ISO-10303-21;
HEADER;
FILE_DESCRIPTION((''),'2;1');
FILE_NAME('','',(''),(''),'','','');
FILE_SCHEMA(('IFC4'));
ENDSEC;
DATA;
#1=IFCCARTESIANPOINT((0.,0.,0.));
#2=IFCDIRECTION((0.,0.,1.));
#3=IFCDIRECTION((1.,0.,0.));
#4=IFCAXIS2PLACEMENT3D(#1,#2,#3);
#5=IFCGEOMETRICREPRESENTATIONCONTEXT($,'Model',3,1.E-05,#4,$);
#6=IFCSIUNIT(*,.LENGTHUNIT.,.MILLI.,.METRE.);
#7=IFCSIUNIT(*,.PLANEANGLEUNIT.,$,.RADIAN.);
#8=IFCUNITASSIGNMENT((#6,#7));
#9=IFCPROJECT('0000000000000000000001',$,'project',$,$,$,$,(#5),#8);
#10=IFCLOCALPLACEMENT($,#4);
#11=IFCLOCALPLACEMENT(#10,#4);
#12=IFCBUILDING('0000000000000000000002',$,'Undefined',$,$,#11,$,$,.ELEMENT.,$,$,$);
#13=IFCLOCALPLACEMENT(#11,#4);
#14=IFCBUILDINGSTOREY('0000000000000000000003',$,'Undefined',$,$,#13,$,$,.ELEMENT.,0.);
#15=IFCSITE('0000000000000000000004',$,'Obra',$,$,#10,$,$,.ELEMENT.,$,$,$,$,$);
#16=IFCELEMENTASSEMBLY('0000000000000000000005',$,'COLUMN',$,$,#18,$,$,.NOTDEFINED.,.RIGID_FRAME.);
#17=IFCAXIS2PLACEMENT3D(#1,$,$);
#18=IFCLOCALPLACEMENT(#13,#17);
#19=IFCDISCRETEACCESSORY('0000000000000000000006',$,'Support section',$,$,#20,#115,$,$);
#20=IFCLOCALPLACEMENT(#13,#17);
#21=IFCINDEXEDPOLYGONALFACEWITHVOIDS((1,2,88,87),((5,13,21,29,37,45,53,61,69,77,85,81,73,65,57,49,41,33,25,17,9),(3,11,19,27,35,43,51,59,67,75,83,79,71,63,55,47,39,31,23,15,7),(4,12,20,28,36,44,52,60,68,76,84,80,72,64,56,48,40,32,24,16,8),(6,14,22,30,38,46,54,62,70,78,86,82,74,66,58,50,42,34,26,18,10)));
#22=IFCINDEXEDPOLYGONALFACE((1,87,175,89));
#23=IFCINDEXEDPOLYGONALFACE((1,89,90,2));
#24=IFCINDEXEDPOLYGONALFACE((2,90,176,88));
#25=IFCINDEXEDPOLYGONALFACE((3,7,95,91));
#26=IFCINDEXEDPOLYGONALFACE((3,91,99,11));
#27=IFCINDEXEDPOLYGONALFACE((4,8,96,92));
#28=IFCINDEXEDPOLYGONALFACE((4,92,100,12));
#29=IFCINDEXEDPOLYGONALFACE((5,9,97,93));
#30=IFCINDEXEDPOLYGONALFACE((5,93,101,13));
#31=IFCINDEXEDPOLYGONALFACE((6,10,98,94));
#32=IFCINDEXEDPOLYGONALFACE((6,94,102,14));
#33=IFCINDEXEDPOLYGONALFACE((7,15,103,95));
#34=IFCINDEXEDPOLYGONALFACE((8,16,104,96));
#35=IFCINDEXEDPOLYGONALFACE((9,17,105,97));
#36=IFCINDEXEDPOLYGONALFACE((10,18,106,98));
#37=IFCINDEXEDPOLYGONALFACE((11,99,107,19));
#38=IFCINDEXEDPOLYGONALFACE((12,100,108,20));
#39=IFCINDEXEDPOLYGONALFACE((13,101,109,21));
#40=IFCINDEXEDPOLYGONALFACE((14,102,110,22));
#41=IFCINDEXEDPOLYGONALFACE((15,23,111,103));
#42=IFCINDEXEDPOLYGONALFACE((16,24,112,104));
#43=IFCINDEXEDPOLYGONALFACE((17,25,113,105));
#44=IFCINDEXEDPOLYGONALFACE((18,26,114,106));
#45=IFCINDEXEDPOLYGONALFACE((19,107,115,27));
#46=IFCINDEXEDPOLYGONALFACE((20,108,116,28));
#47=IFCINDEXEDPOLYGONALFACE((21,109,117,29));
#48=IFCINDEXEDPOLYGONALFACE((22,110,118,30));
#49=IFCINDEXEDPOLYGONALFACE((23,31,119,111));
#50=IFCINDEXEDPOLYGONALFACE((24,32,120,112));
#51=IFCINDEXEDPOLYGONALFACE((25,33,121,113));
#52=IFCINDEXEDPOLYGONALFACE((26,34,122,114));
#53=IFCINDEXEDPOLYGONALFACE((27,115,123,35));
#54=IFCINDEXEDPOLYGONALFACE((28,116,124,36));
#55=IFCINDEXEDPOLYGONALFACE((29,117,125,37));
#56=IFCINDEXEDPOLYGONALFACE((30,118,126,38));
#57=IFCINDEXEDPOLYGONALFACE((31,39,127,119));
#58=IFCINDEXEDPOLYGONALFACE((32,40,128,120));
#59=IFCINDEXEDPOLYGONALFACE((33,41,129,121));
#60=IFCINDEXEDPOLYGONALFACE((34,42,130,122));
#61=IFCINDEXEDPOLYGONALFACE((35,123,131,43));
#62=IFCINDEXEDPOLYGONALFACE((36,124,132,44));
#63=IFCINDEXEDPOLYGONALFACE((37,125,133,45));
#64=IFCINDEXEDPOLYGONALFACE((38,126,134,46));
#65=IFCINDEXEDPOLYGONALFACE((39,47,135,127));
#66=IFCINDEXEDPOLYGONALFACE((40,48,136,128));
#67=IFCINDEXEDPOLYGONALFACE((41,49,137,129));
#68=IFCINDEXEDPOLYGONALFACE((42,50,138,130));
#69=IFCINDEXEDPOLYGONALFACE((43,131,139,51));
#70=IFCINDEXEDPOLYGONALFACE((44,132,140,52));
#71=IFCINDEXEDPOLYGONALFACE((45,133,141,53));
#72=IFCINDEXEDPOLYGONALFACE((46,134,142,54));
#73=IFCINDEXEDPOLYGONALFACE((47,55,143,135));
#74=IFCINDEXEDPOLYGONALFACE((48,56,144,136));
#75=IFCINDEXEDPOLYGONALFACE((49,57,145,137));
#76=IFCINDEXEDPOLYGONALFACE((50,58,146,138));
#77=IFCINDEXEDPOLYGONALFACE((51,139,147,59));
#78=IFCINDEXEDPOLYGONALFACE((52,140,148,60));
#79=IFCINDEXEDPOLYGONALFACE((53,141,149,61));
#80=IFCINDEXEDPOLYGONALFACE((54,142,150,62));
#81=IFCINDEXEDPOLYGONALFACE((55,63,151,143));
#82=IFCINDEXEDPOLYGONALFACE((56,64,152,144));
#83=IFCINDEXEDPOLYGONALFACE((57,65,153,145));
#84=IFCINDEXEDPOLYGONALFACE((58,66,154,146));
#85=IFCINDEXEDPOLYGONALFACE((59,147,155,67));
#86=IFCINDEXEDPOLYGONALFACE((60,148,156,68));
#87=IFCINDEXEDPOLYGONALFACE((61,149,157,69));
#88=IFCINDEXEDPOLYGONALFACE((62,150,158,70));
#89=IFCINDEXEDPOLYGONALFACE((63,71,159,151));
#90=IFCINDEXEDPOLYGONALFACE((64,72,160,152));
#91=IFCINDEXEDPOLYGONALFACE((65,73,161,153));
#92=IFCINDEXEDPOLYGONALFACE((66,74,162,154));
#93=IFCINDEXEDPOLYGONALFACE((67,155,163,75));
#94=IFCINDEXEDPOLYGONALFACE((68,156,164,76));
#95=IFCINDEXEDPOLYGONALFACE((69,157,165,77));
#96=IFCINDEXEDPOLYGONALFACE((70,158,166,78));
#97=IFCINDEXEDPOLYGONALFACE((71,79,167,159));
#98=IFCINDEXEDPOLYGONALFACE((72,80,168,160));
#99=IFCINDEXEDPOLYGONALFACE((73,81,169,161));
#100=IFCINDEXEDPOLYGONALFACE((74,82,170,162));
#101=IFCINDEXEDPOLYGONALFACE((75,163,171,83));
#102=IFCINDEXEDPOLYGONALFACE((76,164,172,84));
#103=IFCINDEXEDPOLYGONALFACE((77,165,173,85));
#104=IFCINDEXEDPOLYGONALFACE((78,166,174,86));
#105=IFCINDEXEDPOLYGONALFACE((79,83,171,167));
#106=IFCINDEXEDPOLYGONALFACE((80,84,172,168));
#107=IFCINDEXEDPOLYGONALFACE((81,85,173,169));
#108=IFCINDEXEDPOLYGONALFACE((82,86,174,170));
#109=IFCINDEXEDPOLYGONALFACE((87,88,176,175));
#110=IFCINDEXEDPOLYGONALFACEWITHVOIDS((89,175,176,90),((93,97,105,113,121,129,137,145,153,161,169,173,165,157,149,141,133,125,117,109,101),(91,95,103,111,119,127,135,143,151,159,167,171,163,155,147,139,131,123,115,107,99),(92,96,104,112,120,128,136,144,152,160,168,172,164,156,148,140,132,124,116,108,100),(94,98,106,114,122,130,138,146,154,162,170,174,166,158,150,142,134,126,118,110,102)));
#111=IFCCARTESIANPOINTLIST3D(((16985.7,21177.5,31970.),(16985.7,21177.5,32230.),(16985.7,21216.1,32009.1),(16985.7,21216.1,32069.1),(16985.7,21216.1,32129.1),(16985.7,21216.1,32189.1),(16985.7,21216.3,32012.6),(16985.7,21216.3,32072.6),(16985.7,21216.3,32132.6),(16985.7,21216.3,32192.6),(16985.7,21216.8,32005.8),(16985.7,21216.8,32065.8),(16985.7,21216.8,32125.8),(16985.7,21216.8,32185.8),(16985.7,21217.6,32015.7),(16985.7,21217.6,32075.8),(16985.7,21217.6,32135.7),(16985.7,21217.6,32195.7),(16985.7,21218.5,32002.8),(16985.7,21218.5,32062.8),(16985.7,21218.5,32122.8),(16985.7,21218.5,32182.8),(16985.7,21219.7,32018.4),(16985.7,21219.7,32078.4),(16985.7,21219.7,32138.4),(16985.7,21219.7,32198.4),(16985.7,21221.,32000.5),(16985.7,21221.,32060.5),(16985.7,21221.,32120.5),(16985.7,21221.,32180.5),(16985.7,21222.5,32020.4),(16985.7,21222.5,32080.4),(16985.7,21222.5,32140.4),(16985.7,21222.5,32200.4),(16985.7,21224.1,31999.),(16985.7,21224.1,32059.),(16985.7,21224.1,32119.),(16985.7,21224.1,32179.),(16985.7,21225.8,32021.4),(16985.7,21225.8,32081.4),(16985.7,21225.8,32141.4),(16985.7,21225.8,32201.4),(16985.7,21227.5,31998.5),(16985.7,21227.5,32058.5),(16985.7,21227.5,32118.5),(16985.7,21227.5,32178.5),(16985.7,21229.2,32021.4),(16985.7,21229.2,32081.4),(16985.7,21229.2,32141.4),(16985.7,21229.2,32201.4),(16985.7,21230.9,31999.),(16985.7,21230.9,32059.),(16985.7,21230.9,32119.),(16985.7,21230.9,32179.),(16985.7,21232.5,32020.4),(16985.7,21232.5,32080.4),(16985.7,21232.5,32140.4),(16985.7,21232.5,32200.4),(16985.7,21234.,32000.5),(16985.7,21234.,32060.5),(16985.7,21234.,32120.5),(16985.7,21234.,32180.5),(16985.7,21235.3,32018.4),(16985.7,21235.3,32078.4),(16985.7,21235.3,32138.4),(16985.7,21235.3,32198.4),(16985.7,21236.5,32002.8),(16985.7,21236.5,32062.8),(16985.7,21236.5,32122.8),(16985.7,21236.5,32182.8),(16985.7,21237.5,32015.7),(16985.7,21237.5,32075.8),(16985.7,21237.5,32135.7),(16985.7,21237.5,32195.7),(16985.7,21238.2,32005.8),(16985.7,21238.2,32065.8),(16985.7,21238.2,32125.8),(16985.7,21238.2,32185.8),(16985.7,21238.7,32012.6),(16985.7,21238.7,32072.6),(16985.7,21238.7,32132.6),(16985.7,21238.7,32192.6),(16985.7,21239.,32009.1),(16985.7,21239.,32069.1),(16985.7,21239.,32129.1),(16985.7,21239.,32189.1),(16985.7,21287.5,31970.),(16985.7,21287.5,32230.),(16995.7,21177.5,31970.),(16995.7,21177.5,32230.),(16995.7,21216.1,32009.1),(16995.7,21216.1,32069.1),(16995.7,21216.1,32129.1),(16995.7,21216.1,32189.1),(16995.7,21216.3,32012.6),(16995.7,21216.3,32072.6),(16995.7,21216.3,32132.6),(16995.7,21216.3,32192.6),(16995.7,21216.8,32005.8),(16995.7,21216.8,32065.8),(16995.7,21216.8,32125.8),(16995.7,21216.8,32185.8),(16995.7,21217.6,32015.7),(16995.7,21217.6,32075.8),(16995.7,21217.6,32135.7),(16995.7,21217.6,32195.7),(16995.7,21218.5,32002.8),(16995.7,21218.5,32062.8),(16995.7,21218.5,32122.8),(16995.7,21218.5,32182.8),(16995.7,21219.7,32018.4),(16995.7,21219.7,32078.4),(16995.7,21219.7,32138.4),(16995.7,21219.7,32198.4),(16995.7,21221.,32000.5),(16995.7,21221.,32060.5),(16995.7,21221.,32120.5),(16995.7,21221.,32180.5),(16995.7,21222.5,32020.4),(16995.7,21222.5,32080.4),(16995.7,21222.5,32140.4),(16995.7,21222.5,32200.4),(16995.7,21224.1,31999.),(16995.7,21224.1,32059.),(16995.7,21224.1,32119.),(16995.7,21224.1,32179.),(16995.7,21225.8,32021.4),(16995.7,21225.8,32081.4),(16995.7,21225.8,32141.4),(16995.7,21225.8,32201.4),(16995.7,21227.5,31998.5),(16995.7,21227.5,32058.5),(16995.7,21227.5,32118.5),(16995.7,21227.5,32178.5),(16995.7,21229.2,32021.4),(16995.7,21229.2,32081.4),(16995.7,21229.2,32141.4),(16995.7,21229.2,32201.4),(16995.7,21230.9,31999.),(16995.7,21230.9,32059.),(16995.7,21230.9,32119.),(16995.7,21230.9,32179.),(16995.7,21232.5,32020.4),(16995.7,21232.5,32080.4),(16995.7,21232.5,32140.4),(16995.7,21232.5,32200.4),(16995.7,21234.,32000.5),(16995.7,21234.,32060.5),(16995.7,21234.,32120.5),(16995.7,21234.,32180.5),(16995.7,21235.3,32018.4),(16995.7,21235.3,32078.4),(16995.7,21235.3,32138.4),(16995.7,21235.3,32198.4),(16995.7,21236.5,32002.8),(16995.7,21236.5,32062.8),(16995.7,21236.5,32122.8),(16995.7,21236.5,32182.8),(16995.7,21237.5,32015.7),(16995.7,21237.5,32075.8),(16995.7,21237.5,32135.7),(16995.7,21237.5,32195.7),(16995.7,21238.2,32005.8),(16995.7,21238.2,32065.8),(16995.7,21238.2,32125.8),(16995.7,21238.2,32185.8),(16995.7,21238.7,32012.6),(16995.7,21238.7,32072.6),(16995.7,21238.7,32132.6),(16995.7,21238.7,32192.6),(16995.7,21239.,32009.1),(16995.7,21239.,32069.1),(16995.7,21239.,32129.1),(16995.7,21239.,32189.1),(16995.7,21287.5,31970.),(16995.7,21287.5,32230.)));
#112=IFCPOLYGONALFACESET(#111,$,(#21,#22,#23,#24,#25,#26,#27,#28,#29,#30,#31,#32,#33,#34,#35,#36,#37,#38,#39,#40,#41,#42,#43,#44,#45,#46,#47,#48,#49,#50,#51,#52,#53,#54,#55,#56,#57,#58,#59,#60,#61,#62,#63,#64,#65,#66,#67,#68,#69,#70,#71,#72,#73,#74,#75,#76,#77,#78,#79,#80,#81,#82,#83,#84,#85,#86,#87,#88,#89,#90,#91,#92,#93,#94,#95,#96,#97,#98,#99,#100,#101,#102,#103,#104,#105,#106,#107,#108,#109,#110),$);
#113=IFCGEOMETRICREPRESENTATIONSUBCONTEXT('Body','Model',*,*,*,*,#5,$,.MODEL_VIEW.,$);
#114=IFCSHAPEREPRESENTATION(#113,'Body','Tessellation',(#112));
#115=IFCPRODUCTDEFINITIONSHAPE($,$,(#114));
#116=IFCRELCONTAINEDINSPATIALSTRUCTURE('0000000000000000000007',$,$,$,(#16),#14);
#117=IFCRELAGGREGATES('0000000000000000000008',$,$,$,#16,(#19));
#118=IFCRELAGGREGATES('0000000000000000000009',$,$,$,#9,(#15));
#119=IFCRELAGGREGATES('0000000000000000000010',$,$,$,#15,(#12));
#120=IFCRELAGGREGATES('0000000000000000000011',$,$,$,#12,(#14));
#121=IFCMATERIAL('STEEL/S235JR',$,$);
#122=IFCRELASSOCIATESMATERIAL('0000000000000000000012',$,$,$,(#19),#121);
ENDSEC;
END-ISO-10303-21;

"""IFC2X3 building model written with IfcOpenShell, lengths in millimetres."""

from ifc_helpers import new_model, si_unit, frame, origin_with_axes, origin_2d_with_axis, place, context, subcontext, project, spatial, rectangle, circle, extrude, source, transform, mapped, material, element, aggregate, save


model = new_model("IFC2X3")

# Units and contexts
model_context = context("Model", 3, precision=1e-05, world=origin_with_axes())
body_context = subcontext(model_context, "Body", "Model", "MODEL_VIEW")
ifc_project = project(units=[si_unit("LENGTHUNIT", "METRE", prefix="MILLI"), si_unit("PLANEANGLEUNIT", "RADIAN")], contexts=[model_context])

# Site, building, storey
site_placement = place(None, origin_with_axes())
site = spatial("IfcSite", under=ifc_project, at=site_placement, Name="Obra", CompositionType="ELEMENT")
building_placement = place(site_placement, origin_with_axes())
building = spatial("IfcBuilding", under=site, at=building_placement, Name="Undefined", CompositionType="ELEMENT")
storey_placement = place(building_placement, origin_with_axes())
storey = spatial("IfcBuildingStorey", under=building, at=storey_placement, Name="Undefined", CompositionType="ELEMENT", Elevation=0.0)

# Element assembly
assembly_1_placement = place(storey_placement, origin_with_axes())
assembly_1 = element("IfcElementAssembly", 1, at=assembly_1_placement, inside=storey, Name="COLUMN", AssemblyPlace="NOTDEFINED", PredefinedType="RIGID_FRAME")
ifc_material_1 = material(Name="STEEL/S235JR")

# Shared definitions
shared_shape_1 = source(origin_with_axes(), body_context, "Body", "SweptSolid", [
    extrude(circle(Radius=11.5, at=origin_2d_with_axis()), frame((0.0, -14.4, 0.0), z_axis=(0.0, 1.0, 0.0), x_axis=(1.0, 0.0, 0.0)), (0.0, 0.0, 1.0), 10.2),
])

# Discrete accessory, opening
discrete_accessory_1_placement = place(assembly_1_placement, frame((16990.7, 21232.5, 31970.0), z_axis=(0.0, 0.0, 1.0), x_axis=(0.0, 1.0, 0.0)))
discrete_accessory_1 = element("IfcDiscreteAccessory", 2, at=discrete_accessory_1_placement, material=ifc_material_1, Name="Support section", context=body_context, shape_type="SweptSolid", body=[
    extrude(rectangle(XDim=10.0, YDim=110.0, at=origin_2d_with_axis()), frame((0.0, 0.0, 260.0), z_axis=(0.0, 0.0, -1.0), x_axis=(0.0, 1.0, 0.0)), (0.0, 0.0, 1.0), 260.0),
])
opening_1_placement = place(assembly_1_placement, frame((17000.0, 21277.5, 32300.0), z_axis=(0.0, -1.0, 0.0), x_axis=(0.0, 0.0, -1.0)))
element("IfcOpeningElement", 3, at=opening_1_placement, cuts=discrete_accessory_1, ObjectType="Opening", context=body_context, shape_type="MappedRepresentation", body=[
    mapped(shared_shape_1, transform((110.0, 0.0, 50.0))),
    mapped(shared_shape_1, transform((170.0, 0.0, 50.0))),
    mapped(shared_shape_1, transform((230.0, 0.0, 50.0))),
    mapped(shared_shape_1, transform((290.0, 0.0, 50.0))),
])
aggregate(assembly_1, [discrete_accessory_1])

save(model, "model.ifc")
